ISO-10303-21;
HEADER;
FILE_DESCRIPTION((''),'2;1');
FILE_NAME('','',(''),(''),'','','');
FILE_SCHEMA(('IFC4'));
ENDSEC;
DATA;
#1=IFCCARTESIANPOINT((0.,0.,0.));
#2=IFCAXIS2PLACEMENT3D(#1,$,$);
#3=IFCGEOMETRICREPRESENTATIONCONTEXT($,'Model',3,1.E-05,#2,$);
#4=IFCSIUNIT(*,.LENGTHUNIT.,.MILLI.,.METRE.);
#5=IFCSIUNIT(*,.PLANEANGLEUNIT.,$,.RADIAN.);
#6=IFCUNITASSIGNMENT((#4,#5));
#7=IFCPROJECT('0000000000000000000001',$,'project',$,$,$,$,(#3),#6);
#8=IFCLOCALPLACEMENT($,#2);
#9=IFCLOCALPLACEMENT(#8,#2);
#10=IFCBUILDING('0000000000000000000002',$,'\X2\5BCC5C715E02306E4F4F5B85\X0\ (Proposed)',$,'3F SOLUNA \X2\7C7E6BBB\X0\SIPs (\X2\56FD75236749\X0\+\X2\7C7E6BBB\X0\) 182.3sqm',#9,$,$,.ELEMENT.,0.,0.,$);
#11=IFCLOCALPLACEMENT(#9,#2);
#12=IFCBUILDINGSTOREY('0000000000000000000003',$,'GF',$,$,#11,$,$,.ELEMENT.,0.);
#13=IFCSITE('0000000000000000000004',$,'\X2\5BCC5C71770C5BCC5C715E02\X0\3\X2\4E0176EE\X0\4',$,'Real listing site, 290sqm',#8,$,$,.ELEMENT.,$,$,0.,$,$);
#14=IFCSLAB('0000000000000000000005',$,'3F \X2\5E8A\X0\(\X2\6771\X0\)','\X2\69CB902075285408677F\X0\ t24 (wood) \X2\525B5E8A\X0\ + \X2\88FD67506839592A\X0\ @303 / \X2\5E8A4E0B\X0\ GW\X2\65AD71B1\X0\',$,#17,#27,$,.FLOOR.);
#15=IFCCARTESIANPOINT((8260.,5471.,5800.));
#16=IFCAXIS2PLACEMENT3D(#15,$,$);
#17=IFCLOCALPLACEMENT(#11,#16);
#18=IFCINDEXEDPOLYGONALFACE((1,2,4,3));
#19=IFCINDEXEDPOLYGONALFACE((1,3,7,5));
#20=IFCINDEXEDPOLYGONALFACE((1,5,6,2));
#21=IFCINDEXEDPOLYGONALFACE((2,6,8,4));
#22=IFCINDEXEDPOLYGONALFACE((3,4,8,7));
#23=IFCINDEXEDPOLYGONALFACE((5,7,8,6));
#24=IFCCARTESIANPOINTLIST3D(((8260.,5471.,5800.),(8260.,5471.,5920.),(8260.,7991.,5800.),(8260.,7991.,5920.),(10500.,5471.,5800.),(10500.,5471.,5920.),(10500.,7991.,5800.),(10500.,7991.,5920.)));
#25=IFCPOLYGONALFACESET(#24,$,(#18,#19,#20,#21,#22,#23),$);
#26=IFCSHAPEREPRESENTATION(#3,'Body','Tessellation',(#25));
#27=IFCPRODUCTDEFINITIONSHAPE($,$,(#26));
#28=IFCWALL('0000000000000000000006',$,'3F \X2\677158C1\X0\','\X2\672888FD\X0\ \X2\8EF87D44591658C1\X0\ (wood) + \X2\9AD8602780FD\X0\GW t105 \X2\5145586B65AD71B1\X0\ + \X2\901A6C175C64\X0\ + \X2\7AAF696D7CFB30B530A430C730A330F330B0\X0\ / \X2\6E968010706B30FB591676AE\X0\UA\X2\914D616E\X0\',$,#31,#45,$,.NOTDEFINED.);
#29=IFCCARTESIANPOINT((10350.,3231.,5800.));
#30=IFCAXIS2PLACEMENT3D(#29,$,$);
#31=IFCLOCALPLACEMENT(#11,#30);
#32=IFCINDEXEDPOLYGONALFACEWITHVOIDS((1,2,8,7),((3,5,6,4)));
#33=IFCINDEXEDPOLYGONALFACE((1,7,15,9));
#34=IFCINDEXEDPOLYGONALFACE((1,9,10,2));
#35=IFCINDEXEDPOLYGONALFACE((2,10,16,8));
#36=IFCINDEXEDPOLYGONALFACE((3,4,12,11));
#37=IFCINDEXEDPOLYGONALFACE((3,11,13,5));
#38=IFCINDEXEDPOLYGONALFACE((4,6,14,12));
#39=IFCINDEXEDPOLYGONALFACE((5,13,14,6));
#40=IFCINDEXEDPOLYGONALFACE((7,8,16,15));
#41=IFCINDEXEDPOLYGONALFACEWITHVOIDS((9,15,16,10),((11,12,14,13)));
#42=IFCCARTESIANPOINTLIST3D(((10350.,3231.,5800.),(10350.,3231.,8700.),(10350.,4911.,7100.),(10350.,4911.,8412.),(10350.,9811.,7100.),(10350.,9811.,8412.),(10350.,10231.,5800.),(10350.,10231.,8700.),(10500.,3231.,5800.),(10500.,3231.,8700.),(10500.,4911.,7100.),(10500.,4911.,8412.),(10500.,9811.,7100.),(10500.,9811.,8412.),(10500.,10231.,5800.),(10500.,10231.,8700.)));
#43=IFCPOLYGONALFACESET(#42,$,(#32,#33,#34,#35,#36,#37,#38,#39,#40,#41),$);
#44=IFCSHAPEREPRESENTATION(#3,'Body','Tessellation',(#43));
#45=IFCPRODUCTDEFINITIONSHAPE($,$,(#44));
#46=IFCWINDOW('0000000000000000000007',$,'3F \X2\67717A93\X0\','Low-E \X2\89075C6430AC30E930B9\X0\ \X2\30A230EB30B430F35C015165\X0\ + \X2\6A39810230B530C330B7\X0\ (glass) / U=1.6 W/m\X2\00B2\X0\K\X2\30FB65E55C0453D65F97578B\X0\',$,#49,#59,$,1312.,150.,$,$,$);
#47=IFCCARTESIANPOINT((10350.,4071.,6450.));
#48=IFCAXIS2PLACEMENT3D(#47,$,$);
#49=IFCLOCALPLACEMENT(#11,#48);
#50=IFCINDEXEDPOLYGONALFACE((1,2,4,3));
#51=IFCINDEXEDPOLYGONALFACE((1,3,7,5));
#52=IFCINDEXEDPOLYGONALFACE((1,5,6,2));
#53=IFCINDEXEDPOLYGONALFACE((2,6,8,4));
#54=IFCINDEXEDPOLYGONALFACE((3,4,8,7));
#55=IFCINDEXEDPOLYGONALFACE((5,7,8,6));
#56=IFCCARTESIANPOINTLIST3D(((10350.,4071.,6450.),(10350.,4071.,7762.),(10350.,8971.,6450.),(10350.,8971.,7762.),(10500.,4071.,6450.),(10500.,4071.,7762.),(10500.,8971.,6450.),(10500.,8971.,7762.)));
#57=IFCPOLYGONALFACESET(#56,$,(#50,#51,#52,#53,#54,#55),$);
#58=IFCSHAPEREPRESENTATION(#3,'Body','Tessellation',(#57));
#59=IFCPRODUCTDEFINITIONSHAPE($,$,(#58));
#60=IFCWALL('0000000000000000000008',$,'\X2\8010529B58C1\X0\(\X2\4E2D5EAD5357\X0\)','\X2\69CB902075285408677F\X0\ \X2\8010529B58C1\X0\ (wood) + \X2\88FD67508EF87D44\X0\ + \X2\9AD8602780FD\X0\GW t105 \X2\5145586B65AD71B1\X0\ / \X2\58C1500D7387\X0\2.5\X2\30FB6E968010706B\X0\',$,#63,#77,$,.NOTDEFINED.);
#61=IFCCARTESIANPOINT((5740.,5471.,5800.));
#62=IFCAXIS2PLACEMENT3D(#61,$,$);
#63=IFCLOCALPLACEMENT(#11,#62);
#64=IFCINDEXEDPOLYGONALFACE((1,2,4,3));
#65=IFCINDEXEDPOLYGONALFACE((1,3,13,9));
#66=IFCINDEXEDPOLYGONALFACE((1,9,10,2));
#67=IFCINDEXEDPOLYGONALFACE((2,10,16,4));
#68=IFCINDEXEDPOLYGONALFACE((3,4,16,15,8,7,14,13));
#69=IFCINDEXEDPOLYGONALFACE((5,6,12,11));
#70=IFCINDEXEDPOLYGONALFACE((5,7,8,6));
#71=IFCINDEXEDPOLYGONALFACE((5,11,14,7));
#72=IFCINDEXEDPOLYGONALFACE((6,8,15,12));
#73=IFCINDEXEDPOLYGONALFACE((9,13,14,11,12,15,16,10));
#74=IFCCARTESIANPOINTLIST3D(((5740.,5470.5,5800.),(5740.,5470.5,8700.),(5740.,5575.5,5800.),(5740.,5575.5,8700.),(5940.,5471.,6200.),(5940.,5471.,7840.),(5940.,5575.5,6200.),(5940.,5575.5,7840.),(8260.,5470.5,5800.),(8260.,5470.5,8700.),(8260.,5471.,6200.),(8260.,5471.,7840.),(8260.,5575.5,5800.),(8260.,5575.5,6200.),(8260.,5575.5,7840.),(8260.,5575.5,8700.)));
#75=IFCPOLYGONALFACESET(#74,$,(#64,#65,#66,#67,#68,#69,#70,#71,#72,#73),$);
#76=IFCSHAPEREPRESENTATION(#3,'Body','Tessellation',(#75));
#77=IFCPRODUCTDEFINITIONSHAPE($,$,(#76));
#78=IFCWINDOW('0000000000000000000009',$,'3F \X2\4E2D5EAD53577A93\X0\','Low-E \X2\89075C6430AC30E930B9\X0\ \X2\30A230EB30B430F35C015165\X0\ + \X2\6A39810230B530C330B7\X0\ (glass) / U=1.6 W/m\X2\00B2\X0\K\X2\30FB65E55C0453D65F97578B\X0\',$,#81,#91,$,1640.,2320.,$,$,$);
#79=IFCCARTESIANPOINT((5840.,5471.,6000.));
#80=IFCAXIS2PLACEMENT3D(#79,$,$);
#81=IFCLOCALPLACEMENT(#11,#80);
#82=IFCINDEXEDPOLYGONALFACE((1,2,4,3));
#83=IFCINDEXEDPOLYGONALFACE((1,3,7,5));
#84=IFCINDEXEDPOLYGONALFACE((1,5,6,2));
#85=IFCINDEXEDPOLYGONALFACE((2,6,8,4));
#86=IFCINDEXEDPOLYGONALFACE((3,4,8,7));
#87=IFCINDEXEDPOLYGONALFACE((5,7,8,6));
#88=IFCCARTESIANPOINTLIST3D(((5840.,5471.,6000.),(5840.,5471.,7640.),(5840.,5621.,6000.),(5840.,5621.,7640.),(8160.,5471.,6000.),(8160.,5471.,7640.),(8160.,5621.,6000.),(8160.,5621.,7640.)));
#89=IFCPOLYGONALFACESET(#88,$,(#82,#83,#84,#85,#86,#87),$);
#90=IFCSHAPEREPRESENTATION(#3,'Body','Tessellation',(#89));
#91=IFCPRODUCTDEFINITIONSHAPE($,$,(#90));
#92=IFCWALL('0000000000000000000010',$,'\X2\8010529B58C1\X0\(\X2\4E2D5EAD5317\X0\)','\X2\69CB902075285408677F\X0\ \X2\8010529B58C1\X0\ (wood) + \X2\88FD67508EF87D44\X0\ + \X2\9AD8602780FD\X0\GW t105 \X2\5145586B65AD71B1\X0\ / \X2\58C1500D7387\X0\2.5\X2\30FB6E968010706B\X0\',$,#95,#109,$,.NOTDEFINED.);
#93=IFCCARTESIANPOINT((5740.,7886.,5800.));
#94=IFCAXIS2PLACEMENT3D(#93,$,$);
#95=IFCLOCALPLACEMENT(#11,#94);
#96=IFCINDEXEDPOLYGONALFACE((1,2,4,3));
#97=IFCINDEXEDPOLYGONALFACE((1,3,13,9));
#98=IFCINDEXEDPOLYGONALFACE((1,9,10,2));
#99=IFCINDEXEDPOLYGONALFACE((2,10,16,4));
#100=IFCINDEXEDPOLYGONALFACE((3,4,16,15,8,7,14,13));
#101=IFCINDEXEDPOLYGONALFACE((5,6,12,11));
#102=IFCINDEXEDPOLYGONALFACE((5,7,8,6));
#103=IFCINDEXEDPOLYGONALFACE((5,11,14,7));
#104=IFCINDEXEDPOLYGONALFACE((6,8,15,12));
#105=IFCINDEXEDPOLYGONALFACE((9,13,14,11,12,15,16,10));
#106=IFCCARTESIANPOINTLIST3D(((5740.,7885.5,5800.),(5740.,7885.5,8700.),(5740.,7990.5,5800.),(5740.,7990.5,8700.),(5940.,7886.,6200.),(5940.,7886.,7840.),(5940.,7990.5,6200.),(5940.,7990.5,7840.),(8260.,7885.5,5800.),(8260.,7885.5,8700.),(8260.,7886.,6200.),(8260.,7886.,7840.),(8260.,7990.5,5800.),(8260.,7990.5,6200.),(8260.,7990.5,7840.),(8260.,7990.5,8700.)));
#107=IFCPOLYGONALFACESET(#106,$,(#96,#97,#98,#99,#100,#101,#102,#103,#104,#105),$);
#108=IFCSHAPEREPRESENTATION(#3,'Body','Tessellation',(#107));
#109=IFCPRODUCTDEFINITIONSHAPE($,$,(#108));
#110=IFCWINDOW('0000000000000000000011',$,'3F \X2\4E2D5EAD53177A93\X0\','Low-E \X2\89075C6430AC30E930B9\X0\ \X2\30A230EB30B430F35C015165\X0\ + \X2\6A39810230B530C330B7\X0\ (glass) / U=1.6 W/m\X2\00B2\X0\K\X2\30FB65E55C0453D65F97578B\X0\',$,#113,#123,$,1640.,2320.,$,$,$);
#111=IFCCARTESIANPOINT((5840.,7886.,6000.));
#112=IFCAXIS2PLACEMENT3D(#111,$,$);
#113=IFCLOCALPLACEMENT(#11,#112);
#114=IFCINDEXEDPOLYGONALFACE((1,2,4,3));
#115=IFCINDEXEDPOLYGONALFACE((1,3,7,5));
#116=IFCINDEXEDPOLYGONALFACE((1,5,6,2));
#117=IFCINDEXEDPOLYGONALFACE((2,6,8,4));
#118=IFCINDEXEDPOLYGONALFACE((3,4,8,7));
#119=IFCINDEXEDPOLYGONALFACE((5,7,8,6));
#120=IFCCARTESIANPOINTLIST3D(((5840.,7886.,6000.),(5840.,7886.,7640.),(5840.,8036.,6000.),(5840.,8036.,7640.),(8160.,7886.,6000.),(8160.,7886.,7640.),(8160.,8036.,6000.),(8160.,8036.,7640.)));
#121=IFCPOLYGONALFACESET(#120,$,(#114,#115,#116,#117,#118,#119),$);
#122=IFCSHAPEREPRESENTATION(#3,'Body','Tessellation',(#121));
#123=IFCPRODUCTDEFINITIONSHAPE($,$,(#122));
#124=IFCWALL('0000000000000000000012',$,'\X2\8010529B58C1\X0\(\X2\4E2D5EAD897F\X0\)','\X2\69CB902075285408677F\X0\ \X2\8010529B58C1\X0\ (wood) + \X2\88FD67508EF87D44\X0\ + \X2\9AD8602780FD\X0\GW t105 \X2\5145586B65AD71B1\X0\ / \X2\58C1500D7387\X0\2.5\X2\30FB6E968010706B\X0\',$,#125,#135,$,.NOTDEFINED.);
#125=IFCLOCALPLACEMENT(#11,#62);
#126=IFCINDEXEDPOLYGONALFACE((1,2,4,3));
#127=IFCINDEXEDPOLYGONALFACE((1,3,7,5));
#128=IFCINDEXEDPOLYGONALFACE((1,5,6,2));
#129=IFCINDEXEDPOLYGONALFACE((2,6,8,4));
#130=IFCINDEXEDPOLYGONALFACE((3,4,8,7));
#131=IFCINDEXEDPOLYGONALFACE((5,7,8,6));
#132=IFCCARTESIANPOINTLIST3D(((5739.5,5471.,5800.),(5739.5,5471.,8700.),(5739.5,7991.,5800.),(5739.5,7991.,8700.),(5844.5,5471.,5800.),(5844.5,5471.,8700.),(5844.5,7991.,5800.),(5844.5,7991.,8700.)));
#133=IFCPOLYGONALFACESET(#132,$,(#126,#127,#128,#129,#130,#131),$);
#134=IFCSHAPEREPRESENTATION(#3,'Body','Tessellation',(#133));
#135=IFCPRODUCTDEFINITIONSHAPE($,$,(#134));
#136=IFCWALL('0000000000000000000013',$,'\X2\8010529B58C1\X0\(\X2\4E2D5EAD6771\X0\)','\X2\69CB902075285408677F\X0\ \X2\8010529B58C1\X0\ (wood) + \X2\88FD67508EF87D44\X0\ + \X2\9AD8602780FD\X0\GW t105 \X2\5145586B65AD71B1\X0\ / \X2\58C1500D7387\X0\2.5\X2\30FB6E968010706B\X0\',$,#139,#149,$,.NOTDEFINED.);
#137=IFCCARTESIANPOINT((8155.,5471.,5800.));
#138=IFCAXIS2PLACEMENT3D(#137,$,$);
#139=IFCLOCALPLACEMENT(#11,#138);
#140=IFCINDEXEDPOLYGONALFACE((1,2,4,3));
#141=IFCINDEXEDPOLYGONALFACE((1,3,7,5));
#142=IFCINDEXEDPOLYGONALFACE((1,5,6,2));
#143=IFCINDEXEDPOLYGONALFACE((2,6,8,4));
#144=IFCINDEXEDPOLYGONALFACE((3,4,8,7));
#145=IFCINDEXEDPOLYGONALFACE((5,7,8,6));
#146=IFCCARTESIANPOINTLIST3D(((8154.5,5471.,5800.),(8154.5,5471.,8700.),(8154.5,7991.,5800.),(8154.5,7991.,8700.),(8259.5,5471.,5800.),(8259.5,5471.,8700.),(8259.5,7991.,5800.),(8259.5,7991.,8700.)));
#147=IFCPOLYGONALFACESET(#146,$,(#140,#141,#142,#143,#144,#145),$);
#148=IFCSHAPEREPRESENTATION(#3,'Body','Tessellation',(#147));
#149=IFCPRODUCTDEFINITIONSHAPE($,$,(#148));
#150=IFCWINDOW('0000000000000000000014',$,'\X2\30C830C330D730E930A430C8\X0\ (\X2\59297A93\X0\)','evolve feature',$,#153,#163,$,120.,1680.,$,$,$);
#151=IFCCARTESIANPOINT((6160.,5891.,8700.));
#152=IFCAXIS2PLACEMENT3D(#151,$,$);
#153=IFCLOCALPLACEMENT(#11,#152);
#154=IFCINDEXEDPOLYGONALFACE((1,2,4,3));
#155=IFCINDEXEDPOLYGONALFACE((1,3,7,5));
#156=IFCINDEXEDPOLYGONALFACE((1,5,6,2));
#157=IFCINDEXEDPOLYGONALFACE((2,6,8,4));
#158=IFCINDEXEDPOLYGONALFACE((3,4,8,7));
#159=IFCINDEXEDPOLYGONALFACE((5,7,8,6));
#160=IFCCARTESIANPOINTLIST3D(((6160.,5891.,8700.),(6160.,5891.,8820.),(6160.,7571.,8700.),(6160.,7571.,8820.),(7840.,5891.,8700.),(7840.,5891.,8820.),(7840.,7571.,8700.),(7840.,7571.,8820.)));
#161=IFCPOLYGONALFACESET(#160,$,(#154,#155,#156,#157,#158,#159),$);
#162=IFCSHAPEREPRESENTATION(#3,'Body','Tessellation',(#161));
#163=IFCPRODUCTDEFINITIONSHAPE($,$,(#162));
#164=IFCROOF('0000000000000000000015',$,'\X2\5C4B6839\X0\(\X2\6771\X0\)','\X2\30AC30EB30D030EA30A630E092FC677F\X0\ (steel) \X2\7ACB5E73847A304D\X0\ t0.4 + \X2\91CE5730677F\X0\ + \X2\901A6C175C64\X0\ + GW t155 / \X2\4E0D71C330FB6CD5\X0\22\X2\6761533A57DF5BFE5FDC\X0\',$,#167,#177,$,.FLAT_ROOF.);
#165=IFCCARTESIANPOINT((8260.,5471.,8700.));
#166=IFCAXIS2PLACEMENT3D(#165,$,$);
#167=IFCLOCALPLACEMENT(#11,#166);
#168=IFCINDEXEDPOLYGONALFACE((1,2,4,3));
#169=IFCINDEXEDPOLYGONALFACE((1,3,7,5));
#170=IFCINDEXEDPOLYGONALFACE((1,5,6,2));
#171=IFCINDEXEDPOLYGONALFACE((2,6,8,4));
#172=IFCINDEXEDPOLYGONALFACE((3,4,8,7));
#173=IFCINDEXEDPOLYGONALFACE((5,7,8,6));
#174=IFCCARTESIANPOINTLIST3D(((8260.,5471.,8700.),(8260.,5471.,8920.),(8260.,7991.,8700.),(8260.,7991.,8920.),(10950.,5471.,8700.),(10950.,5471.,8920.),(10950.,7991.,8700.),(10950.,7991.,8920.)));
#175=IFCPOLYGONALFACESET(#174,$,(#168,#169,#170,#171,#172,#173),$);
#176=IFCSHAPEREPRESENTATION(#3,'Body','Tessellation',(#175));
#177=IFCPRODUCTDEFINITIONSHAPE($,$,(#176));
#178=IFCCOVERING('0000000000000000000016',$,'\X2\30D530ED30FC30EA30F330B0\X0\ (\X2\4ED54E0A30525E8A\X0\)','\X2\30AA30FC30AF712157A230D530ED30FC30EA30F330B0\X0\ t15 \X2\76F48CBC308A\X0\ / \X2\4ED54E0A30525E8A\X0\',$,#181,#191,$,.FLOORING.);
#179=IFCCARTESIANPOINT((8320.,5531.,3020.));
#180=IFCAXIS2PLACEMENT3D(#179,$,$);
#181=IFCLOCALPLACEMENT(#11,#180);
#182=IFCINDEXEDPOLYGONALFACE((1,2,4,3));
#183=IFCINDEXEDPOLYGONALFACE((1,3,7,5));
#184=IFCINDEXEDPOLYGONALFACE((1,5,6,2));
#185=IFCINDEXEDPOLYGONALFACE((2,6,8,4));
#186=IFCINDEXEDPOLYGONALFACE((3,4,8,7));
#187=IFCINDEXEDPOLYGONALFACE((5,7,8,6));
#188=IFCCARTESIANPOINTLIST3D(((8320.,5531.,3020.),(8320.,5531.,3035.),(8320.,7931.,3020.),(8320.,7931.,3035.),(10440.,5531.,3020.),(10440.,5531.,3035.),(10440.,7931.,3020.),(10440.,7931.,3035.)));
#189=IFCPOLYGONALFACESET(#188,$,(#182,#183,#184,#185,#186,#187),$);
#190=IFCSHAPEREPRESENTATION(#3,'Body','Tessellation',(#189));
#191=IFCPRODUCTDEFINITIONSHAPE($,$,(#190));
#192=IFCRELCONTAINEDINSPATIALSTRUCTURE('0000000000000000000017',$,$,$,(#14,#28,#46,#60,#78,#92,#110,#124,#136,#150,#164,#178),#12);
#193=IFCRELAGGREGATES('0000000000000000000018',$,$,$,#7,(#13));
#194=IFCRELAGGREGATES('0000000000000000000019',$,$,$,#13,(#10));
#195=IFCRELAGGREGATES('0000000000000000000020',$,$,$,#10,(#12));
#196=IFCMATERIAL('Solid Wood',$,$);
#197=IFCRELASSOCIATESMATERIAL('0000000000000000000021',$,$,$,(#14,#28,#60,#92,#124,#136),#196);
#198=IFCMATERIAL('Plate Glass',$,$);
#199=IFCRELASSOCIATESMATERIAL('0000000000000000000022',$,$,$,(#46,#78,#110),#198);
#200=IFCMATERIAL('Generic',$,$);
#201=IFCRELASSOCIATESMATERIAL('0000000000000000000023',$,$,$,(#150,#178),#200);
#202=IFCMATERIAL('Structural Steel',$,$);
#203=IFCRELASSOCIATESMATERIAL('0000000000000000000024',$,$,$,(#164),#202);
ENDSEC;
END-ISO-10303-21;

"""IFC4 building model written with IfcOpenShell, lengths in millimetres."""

from ifc_helpers import new_model, si_unit, frame, frame_2d, origin, place, context, project, spatial, rectangle, extrude, material, element, fill, save


model = new_model("IFC4")

# Units and contexts
model_context = context("Model", 3, precision=1e-05, world=origin())
ifc_project = project(units=[si_unit("LENGTHUNIT", "METRE", prefix="MILLI"), si_unit("PLANEANGLEUNIT", "RADIAN")], contexts=[model_context])

# Site, building, storey
site_placement = place(None, origin())
site = spatial("IfcSite", under=ifc_project, at=site_placement, Name="富山県富山市3丁目4", ObjectType="Real listing site, 290sqm", CompositionType="ELEMENT", RefElevation=0.0)
building_placement = place(site_placement, origin())
building = spatial("IfcBuilding", under=site, at=building_placement, Name="富山市の住宅 (Proposed)", ObjectType="3F SOLUNA 籾殻SIPs (国産杉+籾殻) 182.3sqm", CompositionType="ELEMENT", ElevationOfRefHeight=0.0, ElevationOfTerrain=0.0)
storey_placement = place(building_placement, origin())
storey = spatial("IfcBuildingStorey", under=building, at=storey_placement, Name="GF", CompositionType="ELEMENT", Elevation=0.0)

# Slab
ifc_material_1 = material(Name="Solid Wood")
slab_placement = place(storey_placement, frame((8260.0, 5471.0, 5800.0)))
element("IfcSlab", 1, at=slab_placement, inside=storey, material=ifc_material_1, Name="3F 床(東)", Description="構造用合板 t24 (wood) 剛床 + 製材根太 @303 / 床下 GW断熱", PredefinedType="FLOOR", context=model_context, shape_type="SweptSolid", body=[
    extrude(rectangle(XDim=2240.0, YDim=2520.0, at=frame_2d((1120.0, 1260.0))), frame((8260.0, 5471.0, 5800.0)), (0.0, 0.0, 1.0), 120.0),
])

# Walls, openings, windows
wall_1_placement = place(storey_placement, frame((10350.0, 3231.0, 5800.0)))
wall_1 = element("IfcWall", 2, at=wall_1_placement, inside=storey, material=ifc_material_1, Name="3F 東壁", Description="木製 軸組外壁 (wood) + 高性能GW t105 充填断熱 + 通気層 + 窯業系サイディング / 準耐火・外皮UA配慮", PredefinedType="NOTDEFINED", context=model_context, shape_type="SweptSolid", body=[
    extrude(rectangle(XDim=150.0, YDim=7000.0, at=frame_2d((75.0, 3500.0))), frame((10350.0, 3231.0, 5800.0)), (0.0, 0.0, 1.0), 2900.0),
])
opening_1_placement = place(storey_placement, frame((10350.0, 4071.0, 6450.0)))
opening_1 = element("IfcOpeningElement", 3, at=opening_1_placement, cuts=wall_1, PredefinedType="NOTDEFINED", context=model_context, shape_type="SweptSolid", body=[
    extrude(rectangle(XDim=150.0, YDim=4900.0, at=frame_2d((75.0, 2450.0))), frame((10350.0, 4071.0, 6450.0)), (0.0, 0.0, 1.0), 1312.0),
])
ifc_material_2 = material(Name="Plate Glass")
window_1_placement = place(storey_placement, frame((10350.0, 4071.0, 6450.0)))
window_1 = element("IfcWindow", 4, at=window_1_placement, inside=storey, material=ifc_material_2, Name="3F 東窓", Description="Low-E 複層ガラス アルゴン封入 + 樹脂サッシ (glass) / U=1.6 W/m²K・日射取得型", OverallHeight=1312.0, OverallWidth=150.0, context=model_context, shape_type="SweptSolid", body=[
    extrude(rectangle(XDim=150.0, YDim=4900.0, at=frame_2d((75.0, 2450.0))), frame((10350.0, 4071.0, 6450.0)), (0.0, 0.0, 1.0), 1312.0),
])
fill(opening_1, window_1)
wall_2_placement = place(storey_placement, frame((5740.0, 5471.0, 5800.0)))
wall_2 = element("IfcWall", 5, at=wall_2_placement, inside=storey, material=ifc_material_1, Name="耐力壁(中庭南)", Description="構造用合板 耐力壁 (wood) + 製材軸組 + 高性能GW t105 充填断熱 / 壁倍率2.5・準耐火", PredefinedType="NOTDEFINED", context=model_context, shape_type="SweptSolid", body=[
    extrude(rectangle(XDim=2520.0, YDim=105.0, at=frame_2d((1260.0, 52.0))), frame((5740.0, 5471.0, 5800.0)), (0.0, 0.0, 1.0), 2900.0),
])
opening_2_placement = place(storey_placement, frame((5840.0, 5471.0, 6000.0)))
opening_2 = element("IfcOpeningElement", 6, at=opening_2_placement, cuts=wall_2, PredefinedType="NOTDEFINED", context=model_context, shape_type="SweptSolid", body=[
    extrude(rectangle(XDim=2320.0, YDim=150.0, at=frame_2d((1160.0, 75.0))), frame((5840.0, 5471.0, 6000.0)), (0.0, 0.0, 1.0), 1640.0),
])
window_2_placement = place(storey_placement, frame((5840.0, 5471.0, 6000.0)))
window_2 = element("IfcWindow", 7, at=window_2_placement, inside=storey, material=ifc_material_2, Name="3F 中庭南窓", Description="Low-E 複層ガラス アルゴン封入 + 樹脂サッシ (glass) / U=1.6 W/m²K・日射取得型", OverallHeight=1640.0, OverallWidth=2320.0, context=model_context, shape_type="SweptSolid", body=[
    extrude(rectangle(XDim=2320.0, YDim=150.0, at=frame_2d((1160.0, 75.0))), frame((5840.0, 5471.0, 6000.0)), (0.0, 0.0, 1.0), 1640.0),
])
fill(opening_2, window_2)
wall_3_placement = place(storey_placement, frame((5740.0, 7886.0, 5800.0)))
wall_3 = element("IfcWall", 8, at=wall_3_placement, inside=storey, material=ifc_material_1, Name="耐力壁(中庭北)", Description="構造用合板 耐力壁 (wood) + 製材軸組 + 高性能GW t105 充填断熱 / 壁倍率2.5・準耐火", PredefinedType="NOTDEFINED", context=model_context, shape_type="SweptSolid", body=[
    extrude(rectangle(XDim=2520.0, YDim=105.0, at=frame_2d((1260.0, 52.0))), frame((5740.0, 7886.0, 5800.0)), (0.0, 0.0, 1.0), 2900.0),
])
opening_3_placement = place(storey_placement, frame((5840.0, 7886.0, 6000.0)))
opening_3 = element("IfcOpeningElement", 9, at=opening_3_placement, cuts=wall_3, PredefinedType="NOTDEFINED", context=model_context, shape_type="SweptSolid", body=[
    extrude(rectangle(XDim=2320.0, YDim=150.0, at=frame_2d((1160.0, 75.0))), frame((5840.0, 7886.0, 6000.0)), (0.0, 0.0, 1.0), 1640.0),
])
window_3_placement = place(storey_placement, frame((5840.0, 7886.0, 6000.0)))
window_3 = element("IfcWindow", 10, at=window_3_placement, inside=storey, material=ifc_material_2, Name="3F 中庭北窓", Description="Low-E 複層ガラス アルゴン封入 + 樹脂サッシ (glass) / U=1.6 W/m²K・日射取得型", OverallHeight=1640.0, OverallWidth=2320.0, context=model_context, shape_type="SweptSolid", body=[
    extrude(rectangle(XDim=2320.0, YDim=150.0, at=frame_2d((1160.0, 75.0))), frame((5840.0, 7886.0, 6000.0)), (0.0, 0.0, 1.0), 1640.0),
])
fill(opening_3, window_3)

# Walls
wall_4_placement = place(storey_placement, frame((5740.0, 5471.0, 5800.0)))
element("IfcWall", 11, at=wall_4_placement, inside=storey, material=ifc_material_1, Name="耐力壁(中庭西)", Description="構造用合板 耐力壁 (wood) + 製材軸組 + 高性能GW t105 充填断熱 / 壁倍率2.5・準耐火", PredefinedType="NOTDEFINED", context=model_context, shape_type="SweptSolid", body=[
    extrude(rectangle(XDim=105.0, YDim=2520.0, at=frame_2d((52.0, 1260.0))), frame((5740.0, 5471.0, 5800.0)), (0.0, 0.0, 1.0), 2900.0),
])
wall_5_placement = place(storey_placement, frame((8155.0, 5471.0, 5800.0)))
element("IfcWall", 12, at=wall_5_placement, inside=storey, material=ifc_material_1, Name="耐力壁(中庭東)", Description="構造用合板 耐力壁 (wood) + 製材軸組 + 高性能GW t105 充填断熱 / 壁倍率2.5・準耐火", PredefinedType="NOTDEFINED", context=model_context, shape_type="SweptSolid", body=[
    extrude(rectangle(XDim=105.0, YDim=2520.0, at=frame_2d((52.0, 1260.0))), frame((8155.0, 5471.0, 5800.0)), (0.0, 0.0, 1.0), 2900.0),
])

# Window
ifc_material_3 = material(Name="Generic")
window_4_placement = place(storey_placement, frame((6160.0, 5891.0, 8700.0)))
element("IfcWindow", 13, at=window_4_placement, inside=storey, material=ifc_material_3, Name="トップライト (天窓)", Description="evolve feature", OverallHeight=120.0, OverallWidth=1680.0, context=model_context, shape_type="SweptSolid", body=[
    extrude(rectangle(XDim=1680.0, YDim=1680.0, at=frame_2d((840.0, 840.0))), frame((6160.0, 5891.0, 8700.0)), (0.0, 0.0, 1.0), 120.0),
])

# Roof
ifc_material_4 = material(Name="Structural Steel")
for number, where, name in (
    (14, (8260.0, 5471.0, 8700.0), "屋根(東)"),
):
    element("IfcRoof", number, at=place(storey_placement, frame(where)), inside=storey, material=ifc_material_4, Name=name, Description="ガルバリウム鋼板 (steel) 立平葺き t0.4 + 野地板 + 通気層 + GW t155 / 不燃・法22条区域対応", PredefinedType="FLAT_ROOF", context=model_context, shape_type="SweptSolid", body=[
        extrude(rectangle(XDim=2690.0, YDim=2520.0, at=frame_2d((1345.0, 1260.0))), frame((8260.0, 5471.0, 8700.0)), (0.0, 0.0, 1.0), 220.0),
    ])

# Covering
covering_1_placement = place(storey_placement, frame((8320.0, 5531.0, 3020.0)))
element("IfcCovering", 15, at=covering_1_placement, inside=storey, material=ifc_material_3, Name="フローリング (仕上げ床)", Description="オーク無垢フローリング t15 直貼り / 仕上げ床", PredefinedType="FLOORING", context=model_context, shape_type="SweptSolid", body=[
    extrude(rectangle(XDim=2120.0, YDim=2400.0, at=frame_2d((1060.0, 1200.0))), frame((8320.0, 5531.0, 3020.0)), (0.0, 0.0, 1.0), 15.0),
])

save(model, "model.ifc")
